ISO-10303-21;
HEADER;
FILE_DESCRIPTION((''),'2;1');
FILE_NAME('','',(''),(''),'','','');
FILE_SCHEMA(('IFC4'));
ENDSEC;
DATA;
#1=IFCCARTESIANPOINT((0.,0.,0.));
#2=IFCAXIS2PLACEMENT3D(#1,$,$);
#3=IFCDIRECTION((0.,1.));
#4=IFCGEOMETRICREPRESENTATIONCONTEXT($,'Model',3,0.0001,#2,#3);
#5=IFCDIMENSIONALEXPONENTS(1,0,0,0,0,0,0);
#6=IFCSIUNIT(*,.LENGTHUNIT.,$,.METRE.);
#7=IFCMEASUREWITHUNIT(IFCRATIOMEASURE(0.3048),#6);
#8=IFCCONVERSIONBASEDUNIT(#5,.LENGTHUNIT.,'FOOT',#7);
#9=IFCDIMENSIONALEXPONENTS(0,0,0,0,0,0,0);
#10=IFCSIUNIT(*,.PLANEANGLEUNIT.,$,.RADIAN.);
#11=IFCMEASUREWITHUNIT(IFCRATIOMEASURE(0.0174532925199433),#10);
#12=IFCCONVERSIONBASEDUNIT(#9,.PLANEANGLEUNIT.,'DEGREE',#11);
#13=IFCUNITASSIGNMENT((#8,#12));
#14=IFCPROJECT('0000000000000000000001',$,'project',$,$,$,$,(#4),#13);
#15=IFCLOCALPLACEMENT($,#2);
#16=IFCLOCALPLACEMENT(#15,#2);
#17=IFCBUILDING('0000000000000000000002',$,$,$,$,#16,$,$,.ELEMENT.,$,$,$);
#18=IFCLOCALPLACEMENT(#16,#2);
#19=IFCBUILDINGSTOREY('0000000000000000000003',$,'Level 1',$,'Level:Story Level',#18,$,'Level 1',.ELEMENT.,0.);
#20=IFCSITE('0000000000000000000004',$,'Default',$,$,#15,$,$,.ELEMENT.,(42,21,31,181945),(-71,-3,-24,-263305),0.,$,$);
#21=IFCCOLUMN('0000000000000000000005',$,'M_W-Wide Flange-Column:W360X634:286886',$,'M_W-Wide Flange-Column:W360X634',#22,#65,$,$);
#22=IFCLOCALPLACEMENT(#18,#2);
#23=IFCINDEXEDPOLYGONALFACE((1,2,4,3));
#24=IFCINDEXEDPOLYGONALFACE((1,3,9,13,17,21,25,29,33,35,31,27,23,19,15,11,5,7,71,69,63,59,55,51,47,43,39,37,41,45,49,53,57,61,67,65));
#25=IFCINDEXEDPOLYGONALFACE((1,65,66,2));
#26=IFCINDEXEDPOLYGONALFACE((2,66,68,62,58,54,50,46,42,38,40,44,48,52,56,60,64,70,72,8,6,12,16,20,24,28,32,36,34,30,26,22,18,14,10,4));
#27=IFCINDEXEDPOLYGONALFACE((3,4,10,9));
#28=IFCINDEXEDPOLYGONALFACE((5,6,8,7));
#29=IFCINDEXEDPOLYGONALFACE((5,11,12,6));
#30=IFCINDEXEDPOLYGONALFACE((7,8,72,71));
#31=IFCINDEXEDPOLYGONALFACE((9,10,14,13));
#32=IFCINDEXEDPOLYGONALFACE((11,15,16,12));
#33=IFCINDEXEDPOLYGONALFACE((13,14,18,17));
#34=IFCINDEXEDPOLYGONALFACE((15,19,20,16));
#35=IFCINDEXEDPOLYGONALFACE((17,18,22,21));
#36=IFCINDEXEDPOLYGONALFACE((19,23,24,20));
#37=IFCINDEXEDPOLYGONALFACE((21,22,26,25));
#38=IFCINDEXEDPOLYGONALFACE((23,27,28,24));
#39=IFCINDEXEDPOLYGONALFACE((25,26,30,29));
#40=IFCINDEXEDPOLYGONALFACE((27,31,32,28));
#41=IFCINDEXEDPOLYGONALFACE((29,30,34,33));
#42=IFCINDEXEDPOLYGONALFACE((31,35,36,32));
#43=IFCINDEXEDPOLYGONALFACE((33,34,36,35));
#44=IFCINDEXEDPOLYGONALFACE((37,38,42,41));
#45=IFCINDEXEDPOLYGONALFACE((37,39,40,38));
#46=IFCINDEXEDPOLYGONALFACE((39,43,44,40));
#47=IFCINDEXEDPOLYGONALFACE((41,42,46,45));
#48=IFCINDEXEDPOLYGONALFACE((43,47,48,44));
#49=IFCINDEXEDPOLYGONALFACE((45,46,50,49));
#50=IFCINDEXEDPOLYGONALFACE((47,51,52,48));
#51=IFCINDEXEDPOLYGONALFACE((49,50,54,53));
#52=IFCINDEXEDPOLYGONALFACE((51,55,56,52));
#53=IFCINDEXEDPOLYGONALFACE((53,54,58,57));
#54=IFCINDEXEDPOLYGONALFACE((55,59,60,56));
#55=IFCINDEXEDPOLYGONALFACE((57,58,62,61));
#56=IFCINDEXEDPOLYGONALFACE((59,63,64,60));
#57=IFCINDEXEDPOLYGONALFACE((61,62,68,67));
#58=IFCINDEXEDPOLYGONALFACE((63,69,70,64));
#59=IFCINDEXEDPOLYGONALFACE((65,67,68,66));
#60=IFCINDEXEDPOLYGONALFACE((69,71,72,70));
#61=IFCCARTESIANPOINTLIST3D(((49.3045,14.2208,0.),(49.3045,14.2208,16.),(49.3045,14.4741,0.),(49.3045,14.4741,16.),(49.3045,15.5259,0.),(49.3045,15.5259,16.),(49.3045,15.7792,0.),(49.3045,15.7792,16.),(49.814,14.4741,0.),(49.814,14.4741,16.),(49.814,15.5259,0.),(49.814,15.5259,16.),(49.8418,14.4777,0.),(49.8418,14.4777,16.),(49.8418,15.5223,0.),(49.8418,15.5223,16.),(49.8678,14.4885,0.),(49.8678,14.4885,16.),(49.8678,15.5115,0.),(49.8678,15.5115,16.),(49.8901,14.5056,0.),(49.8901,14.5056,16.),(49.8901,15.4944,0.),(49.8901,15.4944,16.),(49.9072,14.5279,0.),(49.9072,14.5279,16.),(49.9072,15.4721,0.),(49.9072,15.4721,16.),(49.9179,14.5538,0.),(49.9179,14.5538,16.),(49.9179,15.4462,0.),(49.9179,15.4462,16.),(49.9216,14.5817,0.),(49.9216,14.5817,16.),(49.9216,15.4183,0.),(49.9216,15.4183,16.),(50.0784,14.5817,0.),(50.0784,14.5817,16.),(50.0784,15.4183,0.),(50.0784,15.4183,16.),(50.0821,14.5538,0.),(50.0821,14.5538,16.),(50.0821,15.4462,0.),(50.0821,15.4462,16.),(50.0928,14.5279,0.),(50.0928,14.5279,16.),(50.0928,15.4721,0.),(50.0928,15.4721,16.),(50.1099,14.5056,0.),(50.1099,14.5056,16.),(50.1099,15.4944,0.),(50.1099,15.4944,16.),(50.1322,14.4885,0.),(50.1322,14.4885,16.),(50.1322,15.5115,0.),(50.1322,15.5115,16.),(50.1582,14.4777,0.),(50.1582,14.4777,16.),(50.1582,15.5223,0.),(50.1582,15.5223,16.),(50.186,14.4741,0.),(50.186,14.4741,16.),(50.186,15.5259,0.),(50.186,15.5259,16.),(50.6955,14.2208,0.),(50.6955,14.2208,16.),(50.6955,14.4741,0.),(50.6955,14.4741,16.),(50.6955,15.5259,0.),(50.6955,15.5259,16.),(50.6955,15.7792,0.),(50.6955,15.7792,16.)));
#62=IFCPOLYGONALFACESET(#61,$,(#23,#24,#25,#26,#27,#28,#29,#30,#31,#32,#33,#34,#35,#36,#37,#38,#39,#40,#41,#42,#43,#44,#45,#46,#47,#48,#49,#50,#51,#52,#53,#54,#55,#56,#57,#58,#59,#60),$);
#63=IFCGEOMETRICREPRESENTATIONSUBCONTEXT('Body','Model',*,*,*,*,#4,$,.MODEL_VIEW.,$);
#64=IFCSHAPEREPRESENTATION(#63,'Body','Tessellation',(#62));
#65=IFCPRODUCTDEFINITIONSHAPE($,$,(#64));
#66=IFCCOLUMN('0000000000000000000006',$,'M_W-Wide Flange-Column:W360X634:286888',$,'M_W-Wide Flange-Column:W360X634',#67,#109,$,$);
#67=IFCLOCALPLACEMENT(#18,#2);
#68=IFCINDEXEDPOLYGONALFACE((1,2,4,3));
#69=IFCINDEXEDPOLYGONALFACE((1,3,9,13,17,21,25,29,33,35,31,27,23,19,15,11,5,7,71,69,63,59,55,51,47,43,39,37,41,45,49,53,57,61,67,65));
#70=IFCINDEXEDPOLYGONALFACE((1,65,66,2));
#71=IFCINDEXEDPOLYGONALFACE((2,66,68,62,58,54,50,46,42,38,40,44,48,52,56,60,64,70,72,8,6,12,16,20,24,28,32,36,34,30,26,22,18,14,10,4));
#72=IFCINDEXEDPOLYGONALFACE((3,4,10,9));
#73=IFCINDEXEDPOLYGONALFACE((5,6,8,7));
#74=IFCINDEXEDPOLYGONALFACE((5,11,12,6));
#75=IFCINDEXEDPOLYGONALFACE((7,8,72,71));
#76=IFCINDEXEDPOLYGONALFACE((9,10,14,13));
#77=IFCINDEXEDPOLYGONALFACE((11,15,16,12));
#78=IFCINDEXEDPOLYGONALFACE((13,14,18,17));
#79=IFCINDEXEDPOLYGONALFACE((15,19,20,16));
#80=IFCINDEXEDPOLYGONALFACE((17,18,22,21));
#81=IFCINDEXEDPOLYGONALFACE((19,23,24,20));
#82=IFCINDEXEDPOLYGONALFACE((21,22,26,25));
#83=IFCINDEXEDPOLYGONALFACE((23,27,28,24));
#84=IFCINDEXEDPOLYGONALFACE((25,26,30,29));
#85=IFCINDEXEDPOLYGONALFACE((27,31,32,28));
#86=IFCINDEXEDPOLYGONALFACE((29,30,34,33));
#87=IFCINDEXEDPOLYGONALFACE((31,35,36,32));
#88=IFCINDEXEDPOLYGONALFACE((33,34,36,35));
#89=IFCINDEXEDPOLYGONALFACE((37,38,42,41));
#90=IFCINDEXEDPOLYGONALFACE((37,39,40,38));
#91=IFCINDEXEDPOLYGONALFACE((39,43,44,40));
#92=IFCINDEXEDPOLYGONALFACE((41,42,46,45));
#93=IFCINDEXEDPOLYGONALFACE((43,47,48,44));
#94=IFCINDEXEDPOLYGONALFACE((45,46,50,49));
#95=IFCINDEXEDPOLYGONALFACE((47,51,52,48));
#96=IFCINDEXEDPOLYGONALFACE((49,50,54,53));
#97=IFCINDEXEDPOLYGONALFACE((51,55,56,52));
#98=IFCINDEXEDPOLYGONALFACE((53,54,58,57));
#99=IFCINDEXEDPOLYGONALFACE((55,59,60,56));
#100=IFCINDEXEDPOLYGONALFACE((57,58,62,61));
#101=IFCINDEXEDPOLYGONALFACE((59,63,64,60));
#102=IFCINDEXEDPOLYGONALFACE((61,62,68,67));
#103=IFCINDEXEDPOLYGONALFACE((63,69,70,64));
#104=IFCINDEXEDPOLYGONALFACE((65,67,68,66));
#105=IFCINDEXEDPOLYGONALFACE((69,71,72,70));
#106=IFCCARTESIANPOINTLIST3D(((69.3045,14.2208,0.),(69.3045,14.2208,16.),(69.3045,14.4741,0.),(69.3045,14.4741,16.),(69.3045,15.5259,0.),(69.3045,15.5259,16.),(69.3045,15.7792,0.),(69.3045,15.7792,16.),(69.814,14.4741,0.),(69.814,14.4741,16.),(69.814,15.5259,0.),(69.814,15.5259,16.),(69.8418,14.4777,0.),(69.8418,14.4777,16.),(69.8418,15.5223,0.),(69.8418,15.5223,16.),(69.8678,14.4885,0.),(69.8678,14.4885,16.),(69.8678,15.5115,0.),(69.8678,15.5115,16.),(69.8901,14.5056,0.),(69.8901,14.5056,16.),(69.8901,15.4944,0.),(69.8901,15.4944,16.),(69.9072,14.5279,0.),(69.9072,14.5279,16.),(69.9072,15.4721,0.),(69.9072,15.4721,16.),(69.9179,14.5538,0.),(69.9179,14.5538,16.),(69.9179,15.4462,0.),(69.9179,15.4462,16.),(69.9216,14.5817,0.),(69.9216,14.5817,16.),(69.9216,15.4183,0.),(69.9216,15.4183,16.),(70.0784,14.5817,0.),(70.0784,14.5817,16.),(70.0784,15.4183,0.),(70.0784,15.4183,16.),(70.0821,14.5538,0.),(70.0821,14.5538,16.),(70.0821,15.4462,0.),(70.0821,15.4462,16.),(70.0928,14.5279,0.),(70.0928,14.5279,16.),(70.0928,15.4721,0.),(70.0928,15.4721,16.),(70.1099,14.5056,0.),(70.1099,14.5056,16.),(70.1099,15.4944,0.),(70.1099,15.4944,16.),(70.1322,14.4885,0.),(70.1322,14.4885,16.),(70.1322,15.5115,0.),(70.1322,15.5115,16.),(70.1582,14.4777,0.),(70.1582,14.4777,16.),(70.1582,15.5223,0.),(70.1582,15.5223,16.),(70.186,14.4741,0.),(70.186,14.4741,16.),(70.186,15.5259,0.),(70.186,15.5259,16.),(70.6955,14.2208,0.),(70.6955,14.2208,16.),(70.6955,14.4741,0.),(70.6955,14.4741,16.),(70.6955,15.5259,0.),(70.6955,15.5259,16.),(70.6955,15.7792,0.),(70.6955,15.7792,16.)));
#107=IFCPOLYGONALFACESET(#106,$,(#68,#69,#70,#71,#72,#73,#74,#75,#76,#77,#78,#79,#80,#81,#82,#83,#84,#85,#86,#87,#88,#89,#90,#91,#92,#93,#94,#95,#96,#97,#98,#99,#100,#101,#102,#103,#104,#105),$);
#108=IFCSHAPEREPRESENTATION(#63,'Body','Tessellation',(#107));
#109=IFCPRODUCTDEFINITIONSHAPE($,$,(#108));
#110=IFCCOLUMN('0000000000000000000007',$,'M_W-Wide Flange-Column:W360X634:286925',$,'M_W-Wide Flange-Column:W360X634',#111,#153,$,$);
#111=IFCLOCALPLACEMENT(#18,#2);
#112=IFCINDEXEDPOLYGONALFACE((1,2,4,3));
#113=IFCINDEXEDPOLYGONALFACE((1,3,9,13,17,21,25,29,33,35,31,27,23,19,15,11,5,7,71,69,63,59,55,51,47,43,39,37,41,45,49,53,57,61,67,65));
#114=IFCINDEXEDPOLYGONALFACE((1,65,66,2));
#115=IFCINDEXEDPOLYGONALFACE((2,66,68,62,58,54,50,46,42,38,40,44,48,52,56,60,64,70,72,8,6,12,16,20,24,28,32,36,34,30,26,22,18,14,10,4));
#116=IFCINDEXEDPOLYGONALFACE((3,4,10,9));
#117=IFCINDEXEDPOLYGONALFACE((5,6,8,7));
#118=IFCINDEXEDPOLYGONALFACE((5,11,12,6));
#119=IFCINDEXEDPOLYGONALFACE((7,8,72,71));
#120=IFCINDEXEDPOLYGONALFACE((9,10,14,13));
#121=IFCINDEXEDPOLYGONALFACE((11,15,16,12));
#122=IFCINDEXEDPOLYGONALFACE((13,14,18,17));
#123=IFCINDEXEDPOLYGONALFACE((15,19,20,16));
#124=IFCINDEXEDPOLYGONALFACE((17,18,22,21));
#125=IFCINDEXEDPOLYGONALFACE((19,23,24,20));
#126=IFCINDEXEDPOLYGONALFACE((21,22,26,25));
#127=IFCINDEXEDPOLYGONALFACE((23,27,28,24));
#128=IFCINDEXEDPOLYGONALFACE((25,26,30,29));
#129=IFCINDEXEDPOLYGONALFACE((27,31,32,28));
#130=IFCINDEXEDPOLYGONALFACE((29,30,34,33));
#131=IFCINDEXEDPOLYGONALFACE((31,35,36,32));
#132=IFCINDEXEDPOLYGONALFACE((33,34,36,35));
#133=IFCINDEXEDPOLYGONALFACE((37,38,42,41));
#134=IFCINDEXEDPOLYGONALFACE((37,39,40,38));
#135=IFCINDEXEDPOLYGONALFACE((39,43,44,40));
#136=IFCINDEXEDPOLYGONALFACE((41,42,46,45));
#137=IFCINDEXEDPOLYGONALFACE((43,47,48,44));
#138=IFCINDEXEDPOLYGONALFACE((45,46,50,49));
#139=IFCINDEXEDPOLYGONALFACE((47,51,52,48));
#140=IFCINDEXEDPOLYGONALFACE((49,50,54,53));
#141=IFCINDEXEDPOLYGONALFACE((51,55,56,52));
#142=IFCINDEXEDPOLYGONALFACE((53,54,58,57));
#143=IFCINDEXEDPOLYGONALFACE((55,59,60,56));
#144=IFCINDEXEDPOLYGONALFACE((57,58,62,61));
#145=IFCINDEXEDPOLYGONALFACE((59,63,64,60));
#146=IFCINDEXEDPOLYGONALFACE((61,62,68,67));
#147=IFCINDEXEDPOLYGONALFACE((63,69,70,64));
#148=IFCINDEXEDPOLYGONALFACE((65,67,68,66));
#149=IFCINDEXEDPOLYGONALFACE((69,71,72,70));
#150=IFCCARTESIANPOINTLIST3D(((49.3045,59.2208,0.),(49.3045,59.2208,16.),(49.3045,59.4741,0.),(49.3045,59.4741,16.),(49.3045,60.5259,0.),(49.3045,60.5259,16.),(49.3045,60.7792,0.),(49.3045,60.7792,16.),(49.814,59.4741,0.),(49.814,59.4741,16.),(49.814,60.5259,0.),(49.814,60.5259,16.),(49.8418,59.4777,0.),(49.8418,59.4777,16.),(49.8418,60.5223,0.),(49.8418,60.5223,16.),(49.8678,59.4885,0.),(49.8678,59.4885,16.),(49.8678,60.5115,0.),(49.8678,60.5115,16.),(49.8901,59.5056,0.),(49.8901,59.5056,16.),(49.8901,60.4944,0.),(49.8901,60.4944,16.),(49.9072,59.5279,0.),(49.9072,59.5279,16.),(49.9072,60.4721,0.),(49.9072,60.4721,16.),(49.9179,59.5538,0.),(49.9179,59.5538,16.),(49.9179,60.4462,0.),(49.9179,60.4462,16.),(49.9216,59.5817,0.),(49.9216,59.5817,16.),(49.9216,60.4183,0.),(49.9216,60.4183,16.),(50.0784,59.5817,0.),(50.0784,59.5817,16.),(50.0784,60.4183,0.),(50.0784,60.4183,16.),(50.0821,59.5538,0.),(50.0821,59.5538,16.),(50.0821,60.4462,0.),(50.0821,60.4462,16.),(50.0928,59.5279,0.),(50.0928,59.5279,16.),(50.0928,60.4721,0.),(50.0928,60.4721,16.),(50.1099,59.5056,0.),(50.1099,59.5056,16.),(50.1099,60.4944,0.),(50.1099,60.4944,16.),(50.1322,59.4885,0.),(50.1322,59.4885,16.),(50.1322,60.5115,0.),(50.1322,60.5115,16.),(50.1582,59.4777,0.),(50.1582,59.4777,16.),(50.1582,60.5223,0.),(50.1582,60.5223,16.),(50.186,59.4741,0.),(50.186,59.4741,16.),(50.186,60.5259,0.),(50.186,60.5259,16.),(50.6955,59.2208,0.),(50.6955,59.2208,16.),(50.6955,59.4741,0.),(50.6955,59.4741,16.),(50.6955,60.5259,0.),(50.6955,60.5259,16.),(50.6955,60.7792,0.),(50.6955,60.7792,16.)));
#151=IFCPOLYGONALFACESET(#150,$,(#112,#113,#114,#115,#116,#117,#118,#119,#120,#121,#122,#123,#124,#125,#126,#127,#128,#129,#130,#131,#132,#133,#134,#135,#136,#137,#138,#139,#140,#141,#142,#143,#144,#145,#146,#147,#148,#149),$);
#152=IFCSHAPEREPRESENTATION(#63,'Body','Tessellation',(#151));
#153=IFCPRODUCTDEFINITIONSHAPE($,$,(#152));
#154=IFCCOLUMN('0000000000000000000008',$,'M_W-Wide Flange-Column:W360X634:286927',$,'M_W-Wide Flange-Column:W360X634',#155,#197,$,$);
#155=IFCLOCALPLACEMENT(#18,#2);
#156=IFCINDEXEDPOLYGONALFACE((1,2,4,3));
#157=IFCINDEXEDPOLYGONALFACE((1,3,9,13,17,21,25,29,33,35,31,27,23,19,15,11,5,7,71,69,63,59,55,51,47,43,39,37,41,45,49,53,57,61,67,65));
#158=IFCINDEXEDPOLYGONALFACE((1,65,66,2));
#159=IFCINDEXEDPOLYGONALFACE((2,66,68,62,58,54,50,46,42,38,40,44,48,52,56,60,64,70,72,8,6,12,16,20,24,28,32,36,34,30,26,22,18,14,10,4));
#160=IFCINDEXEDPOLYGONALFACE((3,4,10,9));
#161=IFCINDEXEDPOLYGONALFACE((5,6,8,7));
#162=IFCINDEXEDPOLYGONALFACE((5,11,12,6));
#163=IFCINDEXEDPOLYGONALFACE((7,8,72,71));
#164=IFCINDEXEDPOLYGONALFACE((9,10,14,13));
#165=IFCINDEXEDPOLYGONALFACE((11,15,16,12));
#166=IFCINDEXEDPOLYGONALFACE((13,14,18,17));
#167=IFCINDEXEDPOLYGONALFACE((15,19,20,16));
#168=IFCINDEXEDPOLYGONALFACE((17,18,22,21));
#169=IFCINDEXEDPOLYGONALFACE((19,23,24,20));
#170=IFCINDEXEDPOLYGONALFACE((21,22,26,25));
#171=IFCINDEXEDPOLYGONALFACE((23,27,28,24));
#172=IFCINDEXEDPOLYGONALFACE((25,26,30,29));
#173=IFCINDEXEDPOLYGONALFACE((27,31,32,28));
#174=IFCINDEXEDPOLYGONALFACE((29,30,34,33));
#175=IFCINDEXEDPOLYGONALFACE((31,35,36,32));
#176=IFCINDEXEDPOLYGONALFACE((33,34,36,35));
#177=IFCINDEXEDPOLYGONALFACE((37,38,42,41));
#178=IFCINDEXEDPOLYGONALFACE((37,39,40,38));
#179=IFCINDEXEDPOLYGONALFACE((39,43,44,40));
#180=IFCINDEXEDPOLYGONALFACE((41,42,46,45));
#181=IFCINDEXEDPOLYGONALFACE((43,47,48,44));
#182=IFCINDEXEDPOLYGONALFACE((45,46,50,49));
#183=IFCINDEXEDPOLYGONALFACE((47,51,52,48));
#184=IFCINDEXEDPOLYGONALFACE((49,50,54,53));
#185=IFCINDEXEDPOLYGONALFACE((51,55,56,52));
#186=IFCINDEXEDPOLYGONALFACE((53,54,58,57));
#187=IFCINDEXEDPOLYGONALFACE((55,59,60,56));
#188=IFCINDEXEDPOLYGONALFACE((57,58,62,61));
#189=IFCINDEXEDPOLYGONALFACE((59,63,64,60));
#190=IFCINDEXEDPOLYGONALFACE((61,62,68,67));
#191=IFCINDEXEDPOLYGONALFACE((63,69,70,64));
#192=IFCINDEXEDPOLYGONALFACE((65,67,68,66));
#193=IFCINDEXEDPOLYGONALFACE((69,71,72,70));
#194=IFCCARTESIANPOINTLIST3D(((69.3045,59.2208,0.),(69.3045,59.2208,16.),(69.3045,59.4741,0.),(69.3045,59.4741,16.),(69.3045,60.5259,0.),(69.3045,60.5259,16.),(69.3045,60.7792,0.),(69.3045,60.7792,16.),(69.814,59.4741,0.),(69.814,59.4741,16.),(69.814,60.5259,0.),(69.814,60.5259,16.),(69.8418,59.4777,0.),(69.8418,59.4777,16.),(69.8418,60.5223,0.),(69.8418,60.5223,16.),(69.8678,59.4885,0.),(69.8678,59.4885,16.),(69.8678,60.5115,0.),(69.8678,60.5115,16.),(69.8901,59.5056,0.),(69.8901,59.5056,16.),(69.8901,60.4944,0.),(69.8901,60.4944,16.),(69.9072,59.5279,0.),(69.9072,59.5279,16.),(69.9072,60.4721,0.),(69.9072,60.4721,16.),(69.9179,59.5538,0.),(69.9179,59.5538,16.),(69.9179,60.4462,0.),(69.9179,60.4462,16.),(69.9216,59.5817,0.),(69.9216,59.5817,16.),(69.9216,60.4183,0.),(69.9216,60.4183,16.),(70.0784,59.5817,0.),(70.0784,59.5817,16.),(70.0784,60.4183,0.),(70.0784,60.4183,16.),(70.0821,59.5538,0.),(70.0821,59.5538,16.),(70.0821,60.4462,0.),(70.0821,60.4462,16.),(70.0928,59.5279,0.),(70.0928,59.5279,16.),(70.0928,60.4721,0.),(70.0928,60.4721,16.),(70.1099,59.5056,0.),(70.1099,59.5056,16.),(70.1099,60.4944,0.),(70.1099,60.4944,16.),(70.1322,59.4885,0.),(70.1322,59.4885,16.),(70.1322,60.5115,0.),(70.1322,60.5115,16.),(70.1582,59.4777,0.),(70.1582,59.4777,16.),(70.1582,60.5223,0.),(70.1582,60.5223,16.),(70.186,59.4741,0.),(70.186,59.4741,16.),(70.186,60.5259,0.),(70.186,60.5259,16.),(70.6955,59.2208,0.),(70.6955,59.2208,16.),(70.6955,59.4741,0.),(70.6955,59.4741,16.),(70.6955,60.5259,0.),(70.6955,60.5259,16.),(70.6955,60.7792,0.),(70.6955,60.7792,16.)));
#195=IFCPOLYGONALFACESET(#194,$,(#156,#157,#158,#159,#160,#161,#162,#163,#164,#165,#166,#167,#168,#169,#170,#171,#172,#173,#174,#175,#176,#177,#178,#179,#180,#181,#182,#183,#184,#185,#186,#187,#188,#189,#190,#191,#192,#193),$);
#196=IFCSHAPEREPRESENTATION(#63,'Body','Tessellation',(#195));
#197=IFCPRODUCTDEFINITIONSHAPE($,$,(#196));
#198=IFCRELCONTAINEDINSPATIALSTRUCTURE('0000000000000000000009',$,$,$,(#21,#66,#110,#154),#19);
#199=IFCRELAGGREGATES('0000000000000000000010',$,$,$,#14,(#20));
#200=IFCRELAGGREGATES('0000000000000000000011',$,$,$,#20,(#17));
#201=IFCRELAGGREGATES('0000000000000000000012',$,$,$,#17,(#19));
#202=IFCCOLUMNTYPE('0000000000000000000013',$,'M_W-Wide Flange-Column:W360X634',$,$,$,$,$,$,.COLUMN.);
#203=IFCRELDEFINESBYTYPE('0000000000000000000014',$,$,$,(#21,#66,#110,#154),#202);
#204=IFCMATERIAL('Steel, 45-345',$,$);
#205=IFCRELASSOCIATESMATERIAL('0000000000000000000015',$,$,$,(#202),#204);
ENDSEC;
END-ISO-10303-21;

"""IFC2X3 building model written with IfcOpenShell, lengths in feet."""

from ifc_helpers import new_model, entity, si_unit, converted_unit, direction, frame, frame_2d, origin, place, context, subcontext, project, spatial, polyline, circle_curve, parameter, trimmed, segment, composite_curve, outline, extrude, source, transform, mapped, material, type_object, type_shapes, element, save


model = new_model("IFC2X3")

# Units and contexts
model_context = context("Model", 3, precision=0.0001, world=origin(), true_north=direction((0.0, 1.0)))
body_context = subcontext(model_context, "Body", "Model", "MODEL_VIEW")
ifc_project = project(units=[converted_unit("LENGTHUNIT", "FOOT", entity("IfcRatioMeasure", 0.3048), si_unit("LENGTHUNIT", "METRE"), dimensions=[1, 0, 0, 0, 0, 0, 0]), converted_unit("PLANEANGLEUNIT", "DEGREE", entity("IfcRatioMeasure", 0.0174532925199433), si_unit("PLANEANGLEUNIT", "RADIAN"), dimensions=[0, 0, 0, 0, 0, 0, 0])], contexts=[model_context])

# Site, building, storey
site_placement = place(None, origin())
site = spatial("IfcSite", under=ifc_project, at=site_placement, Name="Default", CompositionType="ELEMENT", RefLatitude=(42, 21, 31, 181945), RefLongitude=(-71, -3, -24, -263305), RefElevation=0.0)
building_placement = place(site_placement, origin())
building = spatial("IfcBuilding", under=site, at=building_placement, CompositionType="ELEMENT")
storey_placement = place(building_placement, origin())
storey = spatial("IfcBuildingStorey", under=building, at=storey_placement, Name="Level 1", ObjectType="Level:Story Level", LongName="Level 1", CompositionType="ELEMENT", Elevation=0.0)

# Columns
ifc_material = material(Name="Steel, 45-345")
column_type = type_object("IfcColumnType", Name="M_W-Wide Flange-Column:W360X634", PredefinedType="COLUMN", material=ifc_material)
shared_shape = source(origin(), body_context, "Body", "SweptSolid", [
    extrude(outline(composite_curve([segment(polyline([(0.5259, -0.6955), (0.7792, -0.6955)]), True, "CONTINUOUS"), segment(polyline([(0.7792, -0.6955), (0.7792, 0.6955)]), True, "CONTINUOUS"), segment(polyline([(0.7792, 0.6955), (0.5259, 0.6955)]), True, "CONTINUOUS"), segment(polyline([(0.5259, 0.6955), (0.5259, 0.186)]), True, "CONTINUOUS"), segment(trimmed(circle_curve(frame_2d((0.4183, 0.186), x_axis=(1.0, 0.0)), 0.1076), [parameter(270.0)], [parameter(0.0)], True, "PARAMETER"), False, "CONTINUOUS"), segment(polyline([(0.4183, 0.0784), (-0.4183, 0.0784)]), True, "CONTINUOUS"), segment(trimmed(circle_curve(frame_2d((-0.4183, 0.186), x_axis=(0.0, -1.0)), 0.1076), [parameter(270.0)], [parameter(0.0)], True, "PARAMETER"), False, "CONTINUOUS"), segment(polyline([(-0.5259, 0.186), (-0.5259, 0.6955)]), True, "CONTINUOUS"), segment(polyline([(-0.5259, 0.6955), (-0.7792, 0.6955)]), True, "CONTINUOUS"), segment(polyline([(-0.7792, 0.6955), (-0.7792, -0.6955)]), True, "CONTINUOUS"), segment(polyline([(-0.7792, -0.6955), (-0.5259, -0.6955)]), True, "CONTINUOUS"), segment(polyline([(-0.5259, -0.6955), (-0.5259, -0.186)]), True, "CONTINUOUS"), segment(trimmed(circle_curve(frame_2d((-0.4183, -0.186), x_axis=(-1.0, 0.0)), 0.1076), [parameter(270.0)], [parameter(0.0)], True, "PARAMETER"), False, "CONTINUOUS"), segment(polyline([(-0.4183, -0.0784), (0.4183, -0.0784)]), True, "CONTINUOUS"), segment(trimmed(circle_curve(frame_2d((0.4183, -0.186), x_axis=(0.0, 1.0)), 0.1076), [parameter(270.0)], [parameter(0.0)], True, "PARAMETER"), False, "CONTINUOUS"), segment(polyline([(0.5259, -0.186), (0.5259, -0.6955)]), True, "CONTINUOUS")], self_intersect=False)), frame((0.0, 0.0, 0.0), z_axis=(0.0, 0.0, 1.0), x_axis=(0.0, -1.0, 0.0)), (0.0, 0.0, 1.0), 16.0),
])
type_shapes(column_type, [shared_shape])
for number, where, name in (
    (1, (50.0, 15.0, 0.0), "M_W-Wide Flange-Column:W360X634:286886"),
    (2, (70.0, 15.0, 0.0), "M_W-Wide Flange-Column:W360X634:286888"),
    (3, (50.0, 60.0, 0.0), "M_W-Wide Flange-Column:W360X634:286925"),
    (4, (70.0, 60.0, 0.0), "M_W-Wide Flange-Column:W360X634:286927"),
):
    element("IfcColumn", number, at=place(storey_placement, frame(where)), inside=storey, type_object=column_type, Name=name, ObjectType="M_W-Wide Flange-Column:W360X634", context=body_context, shape_type="MappedRepresentation", body=[
        mapped(shared_shape, transform((0.0, 0.0, 0.0), scale=1.0)),
    ])

save(model, "model.ifc")
